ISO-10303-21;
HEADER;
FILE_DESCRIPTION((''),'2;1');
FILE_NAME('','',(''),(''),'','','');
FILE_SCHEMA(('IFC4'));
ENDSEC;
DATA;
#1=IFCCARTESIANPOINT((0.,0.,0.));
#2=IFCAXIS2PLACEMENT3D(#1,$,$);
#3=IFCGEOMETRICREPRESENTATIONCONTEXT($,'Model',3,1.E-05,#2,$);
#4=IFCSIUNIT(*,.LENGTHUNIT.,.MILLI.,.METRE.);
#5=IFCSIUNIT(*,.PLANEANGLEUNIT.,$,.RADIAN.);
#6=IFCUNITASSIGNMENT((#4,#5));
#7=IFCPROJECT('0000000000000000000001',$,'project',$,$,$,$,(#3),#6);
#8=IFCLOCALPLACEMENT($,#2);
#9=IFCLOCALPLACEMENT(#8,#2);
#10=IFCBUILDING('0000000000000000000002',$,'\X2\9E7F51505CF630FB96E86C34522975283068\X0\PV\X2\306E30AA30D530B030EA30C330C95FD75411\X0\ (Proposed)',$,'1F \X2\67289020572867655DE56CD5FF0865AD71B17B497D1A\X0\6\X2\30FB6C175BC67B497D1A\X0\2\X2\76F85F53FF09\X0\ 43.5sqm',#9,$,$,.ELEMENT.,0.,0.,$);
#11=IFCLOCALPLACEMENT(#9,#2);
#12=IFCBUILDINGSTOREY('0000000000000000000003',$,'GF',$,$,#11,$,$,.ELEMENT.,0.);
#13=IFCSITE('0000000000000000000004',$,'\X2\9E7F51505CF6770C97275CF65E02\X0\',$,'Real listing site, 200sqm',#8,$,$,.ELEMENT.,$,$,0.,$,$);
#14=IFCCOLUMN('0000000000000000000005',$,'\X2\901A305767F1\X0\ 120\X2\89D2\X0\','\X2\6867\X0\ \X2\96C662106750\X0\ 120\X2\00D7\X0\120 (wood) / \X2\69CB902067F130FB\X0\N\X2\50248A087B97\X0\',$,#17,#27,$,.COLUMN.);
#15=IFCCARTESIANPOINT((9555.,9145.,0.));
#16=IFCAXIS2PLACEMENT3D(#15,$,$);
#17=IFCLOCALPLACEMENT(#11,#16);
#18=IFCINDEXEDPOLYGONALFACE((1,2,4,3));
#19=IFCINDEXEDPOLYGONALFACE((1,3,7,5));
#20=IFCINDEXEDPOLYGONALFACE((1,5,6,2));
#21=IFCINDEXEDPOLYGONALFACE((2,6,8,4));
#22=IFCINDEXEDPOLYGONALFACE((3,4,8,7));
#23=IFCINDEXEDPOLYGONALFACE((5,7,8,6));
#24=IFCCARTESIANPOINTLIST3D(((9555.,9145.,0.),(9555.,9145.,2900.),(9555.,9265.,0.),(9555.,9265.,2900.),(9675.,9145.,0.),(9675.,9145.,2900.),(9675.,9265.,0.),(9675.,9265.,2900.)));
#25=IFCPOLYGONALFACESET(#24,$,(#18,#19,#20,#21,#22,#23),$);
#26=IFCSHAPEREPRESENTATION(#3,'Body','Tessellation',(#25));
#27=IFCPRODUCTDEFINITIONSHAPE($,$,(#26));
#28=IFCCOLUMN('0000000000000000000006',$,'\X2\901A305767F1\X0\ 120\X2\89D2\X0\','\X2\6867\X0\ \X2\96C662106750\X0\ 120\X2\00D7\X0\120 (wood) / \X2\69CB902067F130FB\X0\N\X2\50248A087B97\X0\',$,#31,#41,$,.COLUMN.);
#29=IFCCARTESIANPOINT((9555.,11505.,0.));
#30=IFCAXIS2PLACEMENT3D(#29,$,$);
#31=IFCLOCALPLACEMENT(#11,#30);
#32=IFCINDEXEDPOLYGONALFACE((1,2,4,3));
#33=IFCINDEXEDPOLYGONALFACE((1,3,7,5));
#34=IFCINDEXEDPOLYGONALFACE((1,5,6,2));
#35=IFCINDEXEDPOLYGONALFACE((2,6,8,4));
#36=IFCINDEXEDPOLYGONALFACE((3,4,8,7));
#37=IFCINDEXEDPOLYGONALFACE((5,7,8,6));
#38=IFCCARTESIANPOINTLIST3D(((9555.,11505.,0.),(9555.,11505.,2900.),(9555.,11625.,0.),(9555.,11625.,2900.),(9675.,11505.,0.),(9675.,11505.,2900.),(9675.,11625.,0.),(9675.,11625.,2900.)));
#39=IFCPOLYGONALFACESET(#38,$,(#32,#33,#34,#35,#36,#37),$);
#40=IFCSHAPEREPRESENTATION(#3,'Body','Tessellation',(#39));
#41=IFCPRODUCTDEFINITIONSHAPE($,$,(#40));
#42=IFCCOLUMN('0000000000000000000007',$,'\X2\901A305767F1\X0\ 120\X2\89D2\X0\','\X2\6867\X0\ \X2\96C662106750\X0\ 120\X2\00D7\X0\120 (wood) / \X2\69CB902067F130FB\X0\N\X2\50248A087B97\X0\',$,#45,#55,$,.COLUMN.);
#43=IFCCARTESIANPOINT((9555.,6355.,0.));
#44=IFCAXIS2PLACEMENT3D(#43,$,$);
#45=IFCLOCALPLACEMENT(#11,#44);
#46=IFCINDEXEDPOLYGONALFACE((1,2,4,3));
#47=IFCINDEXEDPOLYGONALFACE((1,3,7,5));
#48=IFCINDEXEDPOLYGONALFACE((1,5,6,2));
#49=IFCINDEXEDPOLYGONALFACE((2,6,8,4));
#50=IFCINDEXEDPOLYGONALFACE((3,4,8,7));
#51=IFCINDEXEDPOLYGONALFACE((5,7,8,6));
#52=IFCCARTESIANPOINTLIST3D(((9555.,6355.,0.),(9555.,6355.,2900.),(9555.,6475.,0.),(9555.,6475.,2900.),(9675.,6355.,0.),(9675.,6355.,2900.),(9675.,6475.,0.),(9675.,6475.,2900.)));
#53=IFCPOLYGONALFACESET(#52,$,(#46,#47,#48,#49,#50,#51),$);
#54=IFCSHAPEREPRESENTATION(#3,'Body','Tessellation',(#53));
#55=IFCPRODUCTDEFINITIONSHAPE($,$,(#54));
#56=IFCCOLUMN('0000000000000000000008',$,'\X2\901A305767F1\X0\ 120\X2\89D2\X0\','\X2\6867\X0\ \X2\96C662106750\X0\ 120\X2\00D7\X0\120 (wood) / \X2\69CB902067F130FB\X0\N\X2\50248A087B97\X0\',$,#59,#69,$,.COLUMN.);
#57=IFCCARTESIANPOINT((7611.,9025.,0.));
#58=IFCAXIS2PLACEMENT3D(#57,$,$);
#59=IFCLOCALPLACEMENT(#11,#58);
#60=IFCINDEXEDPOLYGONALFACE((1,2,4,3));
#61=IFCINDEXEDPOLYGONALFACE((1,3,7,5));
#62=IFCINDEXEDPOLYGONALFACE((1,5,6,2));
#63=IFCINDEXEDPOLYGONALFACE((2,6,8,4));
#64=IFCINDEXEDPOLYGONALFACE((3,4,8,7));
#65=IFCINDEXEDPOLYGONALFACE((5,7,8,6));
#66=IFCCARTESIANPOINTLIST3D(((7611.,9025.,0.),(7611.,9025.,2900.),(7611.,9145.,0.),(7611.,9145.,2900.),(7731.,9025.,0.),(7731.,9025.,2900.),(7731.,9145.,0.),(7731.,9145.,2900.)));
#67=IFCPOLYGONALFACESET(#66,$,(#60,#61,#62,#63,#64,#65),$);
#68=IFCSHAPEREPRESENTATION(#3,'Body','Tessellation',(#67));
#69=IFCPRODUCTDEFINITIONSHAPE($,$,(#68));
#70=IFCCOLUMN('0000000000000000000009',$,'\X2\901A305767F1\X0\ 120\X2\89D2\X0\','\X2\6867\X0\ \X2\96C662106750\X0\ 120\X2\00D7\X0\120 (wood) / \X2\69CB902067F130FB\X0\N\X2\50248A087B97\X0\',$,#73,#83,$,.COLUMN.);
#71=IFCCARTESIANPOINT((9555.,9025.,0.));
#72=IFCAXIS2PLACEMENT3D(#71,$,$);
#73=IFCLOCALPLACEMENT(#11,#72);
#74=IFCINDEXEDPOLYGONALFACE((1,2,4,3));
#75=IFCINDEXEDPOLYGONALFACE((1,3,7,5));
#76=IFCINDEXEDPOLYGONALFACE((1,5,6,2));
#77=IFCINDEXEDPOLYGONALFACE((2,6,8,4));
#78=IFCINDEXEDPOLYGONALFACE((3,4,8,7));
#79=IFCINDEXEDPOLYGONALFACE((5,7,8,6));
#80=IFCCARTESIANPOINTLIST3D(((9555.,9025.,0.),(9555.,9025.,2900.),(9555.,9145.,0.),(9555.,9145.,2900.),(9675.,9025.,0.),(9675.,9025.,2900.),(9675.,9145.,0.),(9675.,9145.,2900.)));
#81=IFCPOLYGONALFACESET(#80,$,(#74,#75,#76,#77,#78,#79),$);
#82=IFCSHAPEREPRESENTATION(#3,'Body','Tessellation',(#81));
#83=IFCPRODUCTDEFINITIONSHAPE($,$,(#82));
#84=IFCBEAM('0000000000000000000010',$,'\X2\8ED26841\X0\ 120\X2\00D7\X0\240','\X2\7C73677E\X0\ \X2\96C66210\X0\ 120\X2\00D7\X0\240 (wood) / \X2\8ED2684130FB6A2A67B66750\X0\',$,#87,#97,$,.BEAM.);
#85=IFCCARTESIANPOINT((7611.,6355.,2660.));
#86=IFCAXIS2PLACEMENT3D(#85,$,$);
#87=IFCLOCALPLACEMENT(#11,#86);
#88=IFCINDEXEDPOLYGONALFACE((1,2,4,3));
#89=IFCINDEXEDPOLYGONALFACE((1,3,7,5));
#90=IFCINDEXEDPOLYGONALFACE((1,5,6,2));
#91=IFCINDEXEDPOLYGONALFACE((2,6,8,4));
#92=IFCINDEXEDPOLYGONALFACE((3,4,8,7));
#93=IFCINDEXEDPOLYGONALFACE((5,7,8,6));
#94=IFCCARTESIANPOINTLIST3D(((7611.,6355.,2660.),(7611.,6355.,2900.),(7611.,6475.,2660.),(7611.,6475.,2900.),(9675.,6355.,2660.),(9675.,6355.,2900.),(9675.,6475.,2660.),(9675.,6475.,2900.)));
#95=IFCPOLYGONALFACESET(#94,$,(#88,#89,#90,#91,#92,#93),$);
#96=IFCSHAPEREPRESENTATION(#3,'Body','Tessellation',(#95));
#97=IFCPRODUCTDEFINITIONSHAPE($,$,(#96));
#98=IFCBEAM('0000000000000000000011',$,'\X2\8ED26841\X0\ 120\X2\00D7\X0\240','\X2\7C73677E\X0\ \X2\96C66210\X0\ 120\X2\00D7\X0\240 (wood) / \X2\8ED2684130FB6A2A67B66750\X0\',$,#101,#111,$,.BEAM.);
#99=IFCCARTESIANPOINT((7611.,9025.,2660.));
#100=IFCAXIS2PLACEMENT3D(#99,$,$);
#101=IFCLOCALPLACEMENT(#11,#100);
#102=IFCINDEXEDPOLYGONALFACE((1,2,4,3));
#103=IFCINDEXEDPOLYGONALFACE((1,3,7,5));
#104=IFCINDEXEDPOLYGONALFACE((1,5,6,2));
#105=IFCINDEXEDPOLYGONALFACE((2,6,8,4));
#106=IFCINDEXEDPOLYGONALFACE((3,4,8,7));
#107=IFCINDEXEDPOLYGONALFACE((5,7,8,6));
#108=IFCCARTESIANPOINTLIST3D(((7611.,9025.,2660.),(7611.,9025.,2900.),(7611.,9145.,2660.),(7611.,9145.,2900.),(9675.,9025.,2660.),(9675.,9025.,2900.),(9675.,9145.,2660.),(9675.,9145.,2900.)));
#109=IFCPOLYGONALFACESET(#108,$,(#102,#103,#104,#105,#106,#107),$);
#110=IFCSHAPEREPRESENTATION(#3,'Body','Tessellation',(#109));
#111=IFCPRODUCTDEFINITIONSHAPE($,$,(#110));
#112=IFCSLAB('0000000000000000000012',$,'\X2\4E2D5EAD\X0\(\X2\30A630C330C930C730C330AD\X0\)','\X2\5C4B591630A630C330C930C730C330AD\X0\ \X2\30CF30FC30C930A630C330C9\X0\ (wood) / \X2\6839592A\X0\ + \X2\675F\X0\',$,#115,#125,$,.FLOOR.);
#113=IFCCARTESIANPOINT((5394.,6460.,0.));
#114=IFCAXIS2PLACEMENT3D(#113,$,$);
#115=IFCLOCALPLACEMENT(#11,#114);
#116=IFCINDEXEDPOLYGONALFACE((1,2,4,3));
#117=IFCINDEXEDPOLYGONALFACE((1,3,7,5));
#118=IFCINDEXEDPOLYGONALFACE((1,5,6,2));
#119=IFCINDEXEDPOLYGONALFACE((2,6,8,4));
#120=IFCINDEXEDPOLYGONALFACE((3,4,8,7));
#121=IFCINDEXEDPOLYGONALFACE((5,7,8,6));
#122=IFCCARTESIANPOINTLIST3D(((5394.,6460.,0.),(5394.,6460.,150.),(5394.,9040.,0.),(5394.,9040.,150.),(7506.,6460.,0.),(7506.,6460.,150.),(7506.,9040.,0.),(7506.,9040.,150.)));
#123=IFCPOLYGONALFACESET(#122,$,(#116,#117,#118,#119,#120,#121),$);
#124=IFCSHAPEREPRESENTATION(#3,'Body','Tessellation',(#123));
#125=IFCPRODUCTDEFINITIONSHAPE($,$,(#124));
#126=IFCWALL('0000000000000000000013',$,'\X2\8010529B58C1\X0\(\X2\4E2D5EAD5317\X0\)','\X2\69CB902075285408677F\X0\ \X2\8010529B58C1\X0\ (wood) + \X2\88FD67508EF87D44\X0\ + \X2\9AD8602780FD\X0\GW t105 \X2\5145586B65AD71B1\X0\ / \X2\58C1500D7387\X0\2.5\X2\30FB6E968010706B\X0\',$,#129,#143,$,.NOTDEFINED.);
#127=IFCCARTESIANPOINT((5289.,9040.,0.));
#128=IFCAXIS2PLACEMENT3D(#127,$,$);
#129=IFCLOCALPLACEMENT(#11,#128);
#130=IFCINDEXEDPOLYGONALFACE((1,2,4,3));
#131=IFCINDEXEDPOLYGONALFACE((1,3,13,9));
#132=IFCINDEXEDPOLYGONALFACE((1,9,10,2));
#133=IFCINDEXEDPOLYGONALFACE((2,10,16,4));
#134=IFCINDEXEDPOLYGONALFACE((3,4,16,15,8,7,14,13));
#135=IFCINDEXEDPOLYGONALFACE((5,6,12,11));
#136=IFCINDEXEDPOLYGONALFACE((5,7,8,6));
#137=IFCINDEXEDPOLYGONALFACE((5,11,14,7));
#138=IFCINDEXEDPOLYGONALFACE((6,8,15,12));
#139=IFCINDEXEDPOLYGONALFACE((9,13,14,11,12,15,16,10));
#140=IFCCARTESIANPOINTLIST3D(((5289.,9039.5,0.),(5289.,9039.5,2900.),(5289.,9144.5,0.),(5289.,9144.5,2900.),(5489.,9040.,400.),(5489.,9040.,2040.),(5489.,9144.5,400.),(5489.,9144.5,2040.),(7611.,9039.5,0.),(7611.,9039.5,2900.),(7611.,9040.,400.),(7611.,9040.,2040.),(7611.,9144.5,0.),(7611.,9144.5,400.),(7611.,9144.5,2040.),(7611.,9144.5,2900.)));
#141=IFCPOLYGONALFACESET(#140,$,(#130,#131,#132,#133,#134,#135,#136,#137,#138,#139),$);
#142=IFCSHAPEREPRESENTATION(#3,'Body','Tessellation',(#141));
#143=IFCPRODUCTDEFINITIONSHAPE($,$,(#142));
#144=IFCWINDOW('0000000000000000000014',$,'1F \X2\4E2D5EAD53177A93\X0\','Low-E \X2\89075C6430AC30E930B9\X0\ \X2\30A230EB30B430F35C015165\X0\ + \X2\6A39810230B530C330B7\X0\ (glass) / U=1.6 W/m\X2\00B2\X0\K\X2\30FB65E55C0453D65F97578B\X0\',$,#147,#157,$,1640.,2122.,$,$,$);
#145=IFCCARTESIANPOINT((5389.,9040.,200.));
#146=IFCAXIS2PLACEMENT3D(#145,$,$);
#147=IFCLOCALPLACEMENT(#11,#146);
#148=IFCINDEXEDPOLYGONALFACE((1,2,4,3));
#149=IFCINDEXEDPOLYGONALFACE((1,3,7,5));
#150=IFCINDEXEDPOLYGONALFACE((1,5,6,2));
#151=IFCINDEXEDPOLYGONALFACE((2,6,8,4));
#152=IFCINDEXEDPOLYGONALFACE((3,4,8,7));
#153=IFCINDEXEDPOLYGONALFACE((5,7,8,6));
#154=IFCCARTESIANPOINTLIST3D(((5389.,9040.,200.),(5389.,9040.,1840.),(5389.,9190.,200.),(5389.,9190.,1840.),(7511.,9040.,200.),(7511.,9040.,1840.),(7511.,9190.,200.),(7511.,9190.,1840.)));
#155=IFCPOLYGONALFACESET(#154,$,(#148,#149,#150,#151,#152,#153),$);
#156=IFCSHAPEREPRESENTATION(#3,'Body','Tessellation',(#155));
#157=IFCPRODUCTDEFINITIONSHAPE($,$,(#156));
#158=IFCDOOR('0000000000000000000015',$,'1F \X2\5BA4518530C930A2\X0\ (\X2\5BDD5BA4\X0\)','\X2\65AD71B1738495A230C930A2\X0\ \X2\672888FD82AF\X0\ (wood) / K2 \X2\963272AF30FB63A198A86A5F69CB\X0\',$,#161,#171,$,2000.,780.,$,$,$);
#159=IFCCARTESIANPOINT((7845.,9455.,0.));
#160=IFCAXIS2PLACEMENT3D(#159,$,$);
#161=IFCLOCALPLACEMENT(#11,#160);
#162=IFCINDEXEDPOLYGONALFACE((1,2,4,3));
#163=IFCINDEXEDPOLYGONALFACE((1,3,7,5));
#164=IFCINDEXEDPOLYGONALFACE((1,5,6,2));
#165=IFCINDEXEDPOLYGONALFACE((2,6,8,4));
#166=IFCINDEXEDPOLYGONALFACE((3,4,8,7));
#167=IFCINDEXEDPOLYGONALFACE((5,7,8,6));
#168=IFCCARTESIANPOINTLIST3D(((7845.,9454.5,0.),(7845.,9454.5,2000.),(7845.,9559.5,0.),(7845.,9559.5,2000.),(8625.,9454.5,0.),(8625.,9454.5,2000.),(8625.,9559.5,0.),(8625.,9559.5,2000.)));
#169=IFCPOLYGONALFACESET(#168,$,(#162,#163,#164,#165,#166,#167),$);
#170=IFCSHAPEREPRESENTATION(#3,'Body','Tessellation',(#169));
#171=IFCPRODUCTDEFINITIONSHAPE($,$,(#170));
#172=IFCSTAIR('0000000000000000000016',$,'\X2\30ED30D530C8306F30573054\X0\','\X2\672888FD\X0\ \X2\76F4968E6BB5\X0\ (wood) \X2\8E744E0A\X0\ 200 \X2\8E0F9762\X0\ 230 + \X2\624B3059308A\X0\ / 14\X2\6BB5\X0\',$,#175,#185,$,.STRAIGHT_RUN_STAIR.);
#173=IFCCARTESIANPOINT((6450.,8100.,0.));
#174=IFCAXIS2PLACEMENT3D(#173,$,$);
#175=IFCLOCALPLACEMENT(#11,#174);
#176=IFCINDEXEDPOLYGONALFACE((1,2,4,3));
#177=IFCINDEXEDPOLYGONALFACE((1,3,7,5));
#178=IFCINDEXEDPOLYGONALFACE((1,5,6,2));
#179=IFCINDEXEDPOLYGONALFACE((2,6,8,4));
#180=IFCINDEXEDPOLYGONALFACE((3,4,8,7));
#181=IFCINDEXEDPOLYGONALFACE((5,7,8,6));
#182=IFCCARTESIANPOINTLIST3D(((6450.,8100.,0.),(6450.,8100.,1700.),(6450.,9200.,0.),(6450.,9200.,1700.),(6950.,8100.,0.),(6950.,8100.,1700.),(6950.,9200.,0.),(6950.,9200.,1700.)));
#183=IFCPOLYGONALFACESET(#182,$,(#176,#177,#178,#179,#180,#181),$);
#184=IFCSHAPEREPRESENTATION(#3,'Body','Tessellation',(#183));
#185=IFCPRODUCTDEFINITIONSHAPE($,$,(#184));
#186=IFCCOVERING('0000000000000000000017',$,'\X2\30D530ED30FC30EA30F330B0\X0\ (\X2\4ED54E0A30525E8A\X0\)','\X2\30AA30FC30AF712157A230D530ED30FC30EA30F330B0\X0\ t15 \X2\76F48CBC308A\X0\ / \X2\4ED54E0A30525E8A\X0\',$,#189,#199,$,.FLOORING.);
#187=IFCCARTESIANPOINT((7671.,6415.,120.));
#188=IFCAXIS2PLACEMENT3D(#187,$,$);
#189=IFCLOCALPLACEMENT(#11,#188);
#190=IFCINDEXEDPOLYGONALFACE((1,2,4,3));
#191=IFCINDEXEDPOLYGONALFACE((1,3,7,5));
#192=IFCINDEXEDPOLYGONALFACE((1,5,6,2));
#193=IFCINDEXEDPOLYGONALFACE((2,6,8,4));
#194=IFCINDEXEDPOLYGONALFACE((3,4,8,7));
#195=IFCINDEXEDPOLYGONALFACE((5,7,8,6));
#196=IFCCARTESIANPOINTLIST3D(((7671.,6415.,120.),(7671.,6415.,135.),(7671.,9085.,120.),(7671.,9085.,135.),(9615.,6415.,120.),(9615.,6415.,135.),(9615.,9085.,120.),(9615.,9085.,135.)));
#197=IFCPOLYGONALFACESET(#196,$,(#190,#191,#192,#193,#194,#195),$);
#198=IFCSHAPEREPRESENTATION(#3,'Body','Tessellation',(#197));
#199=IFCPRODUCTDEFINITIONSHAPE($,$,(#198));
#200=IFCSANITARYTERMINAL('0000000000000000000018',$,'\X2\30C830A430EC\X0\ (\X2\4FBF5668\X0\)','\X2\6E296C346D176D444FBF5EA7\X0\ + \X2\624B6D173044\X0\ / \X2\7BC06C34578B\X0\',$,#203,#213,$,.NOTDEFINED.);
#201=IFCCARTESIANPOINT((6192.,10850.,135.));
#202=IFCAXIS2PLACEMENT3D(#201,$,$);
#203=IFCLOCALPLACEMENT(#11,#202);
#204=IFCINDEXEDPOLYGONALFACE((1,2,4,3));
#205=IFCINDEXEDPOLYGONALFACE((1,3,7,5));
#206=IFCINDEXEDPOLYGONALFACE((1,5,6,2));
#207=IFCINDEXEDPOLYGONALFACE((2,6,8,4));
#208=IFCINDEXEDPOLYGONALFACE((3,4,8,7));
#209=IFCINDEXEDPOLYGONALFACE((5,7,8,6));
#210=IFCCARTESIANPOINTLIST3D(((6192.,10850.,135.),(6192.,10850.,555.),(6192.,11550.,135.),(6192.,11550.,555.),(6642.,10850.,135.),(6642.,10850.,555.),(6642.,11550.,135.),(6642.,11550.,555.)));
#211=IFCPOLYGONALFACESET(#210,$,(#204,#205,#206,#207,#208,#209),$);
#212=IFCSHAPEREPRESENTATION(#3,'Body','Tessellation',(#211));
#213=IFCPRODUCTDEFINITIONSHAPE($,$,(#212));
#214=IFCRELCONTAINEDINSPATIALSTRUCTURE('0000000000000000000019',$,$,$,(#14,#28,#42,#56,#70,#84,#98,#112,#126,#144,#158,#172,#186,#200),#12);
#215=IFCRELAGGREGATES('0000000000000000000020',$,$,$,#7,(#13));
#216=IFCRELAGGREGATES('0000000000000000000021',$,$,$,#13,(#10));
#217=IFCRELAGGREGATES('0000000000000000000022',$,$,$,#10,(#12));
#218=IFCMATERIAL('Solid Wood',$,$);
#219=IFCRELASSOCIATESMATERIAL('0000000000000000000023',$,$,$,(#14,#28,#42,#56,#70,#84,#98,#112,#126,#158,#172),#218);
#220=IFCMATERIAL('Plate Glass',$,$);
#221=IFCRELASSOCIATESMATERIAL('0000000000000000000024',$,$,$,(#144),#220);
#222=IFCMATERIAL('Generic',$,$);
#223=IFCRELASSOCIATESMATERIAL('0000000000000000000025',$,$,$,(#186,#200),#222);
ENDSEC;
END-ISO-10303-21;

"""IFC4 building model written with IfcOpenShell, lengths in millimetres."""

from ifc_helpers import new_model, si_unit, frame, frame_2d, origin, place, context, project, spatial, rectangle, extrude, material, element, fill, save


model = new_model("IFC4")

# Units and contexts
model_context = context("Model", 3, precision=1e-05, world=origin())
ifc_project = project(units=[si_unit("LENGTHUNIT", "METRE", prefix="MILLI"), si_unit("PLANEANGLEUNIT", "RADIAN")], contexts=[model_context])

# Site, building, storey
site_placement = place(None, origin())
site = spatial("IfcSite", under=ifc_project, at=site_placement, Name="鹿児島県霧島市", ObjectType="Real listing site, 200sqm", CompositionType="ELEMENT", RefElevation=0.0)
building_placement = place(site_placement, origin())
building = spatial("IfcBuilding", under=site, at=building_placement, Name="鹿児島・雨水利用とPVのオフグリッド志向 (Proposed)", ObjectType="1F 木造在来工法（断熱等級6・気密等級2相当） 43.5sqm", CompositionType="ELEMENT", ElevationOfRefHeight=0.0, ElevationOfTerrain=0.0)
storey_placement = place(building_placement, origin())
storey = spatial("IfcBuildingStorey", under=building, at=storey_placement, Name="GF", CompositionType="ELEMENT", Elevation=0.0)

# Columns
ifc_material_1 = material(Name="Solid Wood")
column_1_placement = place(storey_placement, frame((9555.0, 9145.0, 0.0)))
element("IfcColumn", 1, at=column_1_placement, inside=storey, material=ifc_material_1, Name="通し柱 120角", Description="桧 集成材 120×120 (wood) / 構造柱・N値計算", PredefinedType="COLUMN", context=model_context, shape_type="SweptSolid", body=[
    extrude(rectangle(XDim=120.0, YDim=120.0, at=frame_2d((60.0, 60.0))), frame((9555.0, 9145.0, 0.0)), (0.0, 0.0, 1.0), 2900.0),
])
column_2_placement = place(storey_placement, frame((9555.0, 11505.0, 0.0)))
element("IfcColumn", 2, at=column_2_placement, inside=storey, material=ifc_material_1, Name="通し柱 120角", Description="桧 集成材 120×120 (wood) / 構造柱・N値計算", PredefinedType="COLUMN", context=model_context, shape_type="SweptSolid", body=[
    extrude(rectangle(XDim=120.0, YDim=120.0, at=frame_2d((60.0, 60.0))), frame((9555.0, 11505.0, 0.0)), (0.0, 0.0, 1.0), 2900.0),
])
column_3_placement = place(storey_placement, frame((9555.0, 6355.0, 0.0)))
element("IfcColumn", 3, at=column_3_placement, inside=storey, material=ifc_material_1, Name="通し柱 120角", Description="桧 集成材 120×120 (wood) / 構造柱・N値計算", PredefinedType="COLUMN", context=model_context, shape_type="SweptSolid", body=[
    extrude(rectangle(XDim=120.0, YDim=120.0, at=frame_2d((60.0, 60.0))), frame((9555.0, 6355.0, 0.0)), (0.0, 0.0, 1.0), 2900.0),
])
column_4_placement = place(storey_placement, frame((7611.0, 9025.0, 0.0)))
element("IfcColumn", 4, at=column_4_placement, inside=storey, material=ifc_material_1, Name="通し柱 120角", Description="桧 集成材 120×120 (wood) / 構造柱・N値計算", PredefinedType="COLUMN", context=model_context, shape_type="SweptSolid", body=[
    extrude(rectangle(XDim=120.0, YDim=120.0, at=frame_2d((60.0, 60.0))), frame((7611.0, 9025.0, 0.0)), (0.0, 0.0, 1.0), 2900.0),
])
column_5_placement = place(storey_placement, frame((9555.0, 9025.0, 0.0)))
element("IfcColumn", 5, at=column_5_placement, inside=storey, material=ifc_material_1, Name="通し柱 120角", Description="桧 集成材 120×120 (wood) / 構造柱・N値計算", PredefinedType="COLUMN", context=model_context, shape_type="SweptSolid", body=[
    extrude(rectangle(XDim=120.0, YDim=120.0, at=frame_2d((60.0, 60.0))), frame((9555.0, 9025.0, 0.0)), (0.0, 0.0, 1.0), 2900.0),
])

# Beams
beam_1_placement = place(storey_placement, frame((7611.0, 6355.0, 2660.0)))
element("IfcBeam", 6, at=beam_1_placement, inside=storey, material=ifc_material_1, Name="軒桁 120×240", Description="米松 集成 120×240 (wood) / 軒桁・横架材", PredefinedType="BEAM", context=model_context, shape_type="SweptSolid", body=[
    extrude(rectangle(XDim=2064.0, YDim=120.0, at=frame_2d((1032.0, 60.0))), frame((7611.0, 6355.0, 2660.0)), (0.0, 0.0, 1.0), 240.0),
])
beam_2_placement = place(storey_placement, frame((7611.0, 9025.0, 2660.0)))
element("IfcBeam", 7, at=beam_2_placement, inside=storey, material=ifc_material_1, Name="軒桁 120×240", Description="米松 集成 120×240 (wood) / 軒桁・横架材", PredefinedType="BEAM", context=model_context, shape_type="SweptSolid", body=[
    extrude(rectangle(XDim=2064.0, YDim=120.0, at=frame_2d((1032.0, 60.0))), frame((7611.0, 9025.0, 2660.0)), (0.0, 0.0, 1.0), 240.0),
])

# Slab
slab_placement = place(storey_placement, frame((5394.0, 6460.0, 0.0)))
element("IfcSlab", 8, at=slab_placement, inside=storey, material=ifc_material_1, Name="中庭(ウッドデッキ)", Description="屋外ウッドデッキ ハードウッド (wood) / 根太 + 束", PredefinedType="FLOOR", context=model_context, shape_type="SweptSolid", body=[
    extrude(rectangle(XDim=2112.0, YDim=2580.0, at=frame_2d((1056.0, 1290.0))), frame((5394.0, 6460.0, 0.0)), (0.0, 0.0, 1.0), 150.0),
])

# Wall, opening, window
wall_1_placement = place(storey_placement, frame((5289.0, 9040.0, 0.0)))
wall_1 = element("IfcWall", 9, at=wall_1_placement, inside=storey, material=ifc_material_1, Name="耐力壁(中庭北)", Description="構造用合板 耐力壁 (wood) + 製材軸組 + 高性能GW t105 充填断熱 / 壁倍率2.5・準耐火", PredefinedType="NOTDEFINED", context=model_context, shape_type="SweptSolid", body=[
    extrude(rectangle(XDim=2322.0, YDim=105.0, at=frame_2d((1161.0, 52.0))), frame((5289.0, 9040.0, 0.0)), (0.0, 0.0, 1.0), 2900.0),
])
opening_placement = place(storey_placement, frame((5389.0, 9040.0, 200.0)))
opening = element("IfcOpeningElement", 10, at=opening_placement, cuts=wall_1, PredefinedType="NOTDEFINED", context=model_context, shape_type="SweptSolid", body=[
    extrude(rectangle(XDim=2122.0, YDim=150.0, at=frame_2d((1061.0, 75.0))), frame((5389.0, 9040.0, 200.0)), (0.0, 0.0, 1.0), 1640.0),
])
ifc_material_2 = material(Name="Plate Glass")
window_placement = place(storey_placement, frame((5389.0, 9040.0, 200.0)))
window = element("IfcWindow", 11, at=window_placement, inside=storey, material=ifc_material_2, Name="1F 中庭北窓", Description="Low-E 複層ガラス アルゴン封入 + 樹脂サッシ (glass) / U=1.6 W/m²K・日射取得型", OverallHeight=1640.0, OverallWidth=2122.0, context=model_context, shape_type="SweptSolid", body=[
    extrude(rectangle(XDim=2122.0, YDim=150.0, at=frame_2d((1061.0, 75.0))), frame((5389.0, 9040.0, 200.0)), (0.0, 0.0, 1.0), 1640.0),
])
fill(opening, window)

# Door
door_placement = place(storey_placement, frame((7845.0, 9455.0, 0.0)))
element("IfcDoor", 12, at=door_placement, inside=storey, material=ifc_material_1, Name="1F 室内ドア (寝室)", Description="断熱玄関ドア 木製芯 (wood) / K2 防犯・採風機構", OverallHeight=2000.0, OverallWidth=780.0, context=model_context, shape_type="SweptSolid", body=[
    extrude(rectangle(XDim=780.0, YDim=105.0, at=frame_2d((390.0, 52.0))), frame((7845.0, 9455.0, 0.0)), (0.0, 0.0, 1.0), 2000.0),
])

# Stair
stair_placement = place(storey_placement, frame((6450.0, 8100.0, 0.0)))
element("IfcStair", 13, at=stair_placement, inside=storey, material=ifc_material_1, Name="ロフトはしご", Description="木製 直階段 (wood) 蹴上 200 踏面 230 + 手すり / 14段", PredefinedType="STRAIGHT_RUN_STAIR", context=model_context, shape_type="SweptSolid", body=[
    extrude(rectangle(XDim=500.0, YDim=1100.0, at=frame_2d((250.0, 550.0))), frame((6450.0, 8100.0, 0.0)), (0.0, 0.0, 1.0), 1700.0),
])

# Covering
ifc_material_3 = material(Name="Generic")
covering_placement = place(storey_placement, frame((7671.0, 6415.0, 120.0)))
element("IfcCovering", 14, at=covering_placement, inside=storey, material=ifc_material_3, Name="フローリング (仕上げ床)", Description="オーク無垢フローリング t15 直貼り / 仕上げ床", PredefinedType="FLOORING", context=model_context, shape_type="SweptSolid", body=[
    extrude(rectangle(XDim=1944.0, YDim=2670.0, at=frame_2d((972.0, 1335.0))), frame((7671.0, 6415.0, 120.0)), (0.0, 0.0, 1.0), 15.0),
])

# Sanitary terminal
sanitary_terminal_placement = place(storey_placement, frame((6192.0, 10850.0, 135.0)))
element("IfcSanitaryTerminal", 15, at=sanitary_terminal_placement, inside=storey, material=ifc_material_3, Name="トイレ (便器)", Description="温水洗浄便座 + 手洗い / 節水型", PredefinedType="NOTDEFINED", context=model_context, shape_type="SweptSolid", body=[
    extrude(rectangle(XDim=450.0, YDim=700.0, at=frame_2d((225.0, 350.0))), frame((6192.0, 10850.0, 135.0)), (0.0, 0.0, 1.0), 420.0),
])

save(model, "model.ifc")
